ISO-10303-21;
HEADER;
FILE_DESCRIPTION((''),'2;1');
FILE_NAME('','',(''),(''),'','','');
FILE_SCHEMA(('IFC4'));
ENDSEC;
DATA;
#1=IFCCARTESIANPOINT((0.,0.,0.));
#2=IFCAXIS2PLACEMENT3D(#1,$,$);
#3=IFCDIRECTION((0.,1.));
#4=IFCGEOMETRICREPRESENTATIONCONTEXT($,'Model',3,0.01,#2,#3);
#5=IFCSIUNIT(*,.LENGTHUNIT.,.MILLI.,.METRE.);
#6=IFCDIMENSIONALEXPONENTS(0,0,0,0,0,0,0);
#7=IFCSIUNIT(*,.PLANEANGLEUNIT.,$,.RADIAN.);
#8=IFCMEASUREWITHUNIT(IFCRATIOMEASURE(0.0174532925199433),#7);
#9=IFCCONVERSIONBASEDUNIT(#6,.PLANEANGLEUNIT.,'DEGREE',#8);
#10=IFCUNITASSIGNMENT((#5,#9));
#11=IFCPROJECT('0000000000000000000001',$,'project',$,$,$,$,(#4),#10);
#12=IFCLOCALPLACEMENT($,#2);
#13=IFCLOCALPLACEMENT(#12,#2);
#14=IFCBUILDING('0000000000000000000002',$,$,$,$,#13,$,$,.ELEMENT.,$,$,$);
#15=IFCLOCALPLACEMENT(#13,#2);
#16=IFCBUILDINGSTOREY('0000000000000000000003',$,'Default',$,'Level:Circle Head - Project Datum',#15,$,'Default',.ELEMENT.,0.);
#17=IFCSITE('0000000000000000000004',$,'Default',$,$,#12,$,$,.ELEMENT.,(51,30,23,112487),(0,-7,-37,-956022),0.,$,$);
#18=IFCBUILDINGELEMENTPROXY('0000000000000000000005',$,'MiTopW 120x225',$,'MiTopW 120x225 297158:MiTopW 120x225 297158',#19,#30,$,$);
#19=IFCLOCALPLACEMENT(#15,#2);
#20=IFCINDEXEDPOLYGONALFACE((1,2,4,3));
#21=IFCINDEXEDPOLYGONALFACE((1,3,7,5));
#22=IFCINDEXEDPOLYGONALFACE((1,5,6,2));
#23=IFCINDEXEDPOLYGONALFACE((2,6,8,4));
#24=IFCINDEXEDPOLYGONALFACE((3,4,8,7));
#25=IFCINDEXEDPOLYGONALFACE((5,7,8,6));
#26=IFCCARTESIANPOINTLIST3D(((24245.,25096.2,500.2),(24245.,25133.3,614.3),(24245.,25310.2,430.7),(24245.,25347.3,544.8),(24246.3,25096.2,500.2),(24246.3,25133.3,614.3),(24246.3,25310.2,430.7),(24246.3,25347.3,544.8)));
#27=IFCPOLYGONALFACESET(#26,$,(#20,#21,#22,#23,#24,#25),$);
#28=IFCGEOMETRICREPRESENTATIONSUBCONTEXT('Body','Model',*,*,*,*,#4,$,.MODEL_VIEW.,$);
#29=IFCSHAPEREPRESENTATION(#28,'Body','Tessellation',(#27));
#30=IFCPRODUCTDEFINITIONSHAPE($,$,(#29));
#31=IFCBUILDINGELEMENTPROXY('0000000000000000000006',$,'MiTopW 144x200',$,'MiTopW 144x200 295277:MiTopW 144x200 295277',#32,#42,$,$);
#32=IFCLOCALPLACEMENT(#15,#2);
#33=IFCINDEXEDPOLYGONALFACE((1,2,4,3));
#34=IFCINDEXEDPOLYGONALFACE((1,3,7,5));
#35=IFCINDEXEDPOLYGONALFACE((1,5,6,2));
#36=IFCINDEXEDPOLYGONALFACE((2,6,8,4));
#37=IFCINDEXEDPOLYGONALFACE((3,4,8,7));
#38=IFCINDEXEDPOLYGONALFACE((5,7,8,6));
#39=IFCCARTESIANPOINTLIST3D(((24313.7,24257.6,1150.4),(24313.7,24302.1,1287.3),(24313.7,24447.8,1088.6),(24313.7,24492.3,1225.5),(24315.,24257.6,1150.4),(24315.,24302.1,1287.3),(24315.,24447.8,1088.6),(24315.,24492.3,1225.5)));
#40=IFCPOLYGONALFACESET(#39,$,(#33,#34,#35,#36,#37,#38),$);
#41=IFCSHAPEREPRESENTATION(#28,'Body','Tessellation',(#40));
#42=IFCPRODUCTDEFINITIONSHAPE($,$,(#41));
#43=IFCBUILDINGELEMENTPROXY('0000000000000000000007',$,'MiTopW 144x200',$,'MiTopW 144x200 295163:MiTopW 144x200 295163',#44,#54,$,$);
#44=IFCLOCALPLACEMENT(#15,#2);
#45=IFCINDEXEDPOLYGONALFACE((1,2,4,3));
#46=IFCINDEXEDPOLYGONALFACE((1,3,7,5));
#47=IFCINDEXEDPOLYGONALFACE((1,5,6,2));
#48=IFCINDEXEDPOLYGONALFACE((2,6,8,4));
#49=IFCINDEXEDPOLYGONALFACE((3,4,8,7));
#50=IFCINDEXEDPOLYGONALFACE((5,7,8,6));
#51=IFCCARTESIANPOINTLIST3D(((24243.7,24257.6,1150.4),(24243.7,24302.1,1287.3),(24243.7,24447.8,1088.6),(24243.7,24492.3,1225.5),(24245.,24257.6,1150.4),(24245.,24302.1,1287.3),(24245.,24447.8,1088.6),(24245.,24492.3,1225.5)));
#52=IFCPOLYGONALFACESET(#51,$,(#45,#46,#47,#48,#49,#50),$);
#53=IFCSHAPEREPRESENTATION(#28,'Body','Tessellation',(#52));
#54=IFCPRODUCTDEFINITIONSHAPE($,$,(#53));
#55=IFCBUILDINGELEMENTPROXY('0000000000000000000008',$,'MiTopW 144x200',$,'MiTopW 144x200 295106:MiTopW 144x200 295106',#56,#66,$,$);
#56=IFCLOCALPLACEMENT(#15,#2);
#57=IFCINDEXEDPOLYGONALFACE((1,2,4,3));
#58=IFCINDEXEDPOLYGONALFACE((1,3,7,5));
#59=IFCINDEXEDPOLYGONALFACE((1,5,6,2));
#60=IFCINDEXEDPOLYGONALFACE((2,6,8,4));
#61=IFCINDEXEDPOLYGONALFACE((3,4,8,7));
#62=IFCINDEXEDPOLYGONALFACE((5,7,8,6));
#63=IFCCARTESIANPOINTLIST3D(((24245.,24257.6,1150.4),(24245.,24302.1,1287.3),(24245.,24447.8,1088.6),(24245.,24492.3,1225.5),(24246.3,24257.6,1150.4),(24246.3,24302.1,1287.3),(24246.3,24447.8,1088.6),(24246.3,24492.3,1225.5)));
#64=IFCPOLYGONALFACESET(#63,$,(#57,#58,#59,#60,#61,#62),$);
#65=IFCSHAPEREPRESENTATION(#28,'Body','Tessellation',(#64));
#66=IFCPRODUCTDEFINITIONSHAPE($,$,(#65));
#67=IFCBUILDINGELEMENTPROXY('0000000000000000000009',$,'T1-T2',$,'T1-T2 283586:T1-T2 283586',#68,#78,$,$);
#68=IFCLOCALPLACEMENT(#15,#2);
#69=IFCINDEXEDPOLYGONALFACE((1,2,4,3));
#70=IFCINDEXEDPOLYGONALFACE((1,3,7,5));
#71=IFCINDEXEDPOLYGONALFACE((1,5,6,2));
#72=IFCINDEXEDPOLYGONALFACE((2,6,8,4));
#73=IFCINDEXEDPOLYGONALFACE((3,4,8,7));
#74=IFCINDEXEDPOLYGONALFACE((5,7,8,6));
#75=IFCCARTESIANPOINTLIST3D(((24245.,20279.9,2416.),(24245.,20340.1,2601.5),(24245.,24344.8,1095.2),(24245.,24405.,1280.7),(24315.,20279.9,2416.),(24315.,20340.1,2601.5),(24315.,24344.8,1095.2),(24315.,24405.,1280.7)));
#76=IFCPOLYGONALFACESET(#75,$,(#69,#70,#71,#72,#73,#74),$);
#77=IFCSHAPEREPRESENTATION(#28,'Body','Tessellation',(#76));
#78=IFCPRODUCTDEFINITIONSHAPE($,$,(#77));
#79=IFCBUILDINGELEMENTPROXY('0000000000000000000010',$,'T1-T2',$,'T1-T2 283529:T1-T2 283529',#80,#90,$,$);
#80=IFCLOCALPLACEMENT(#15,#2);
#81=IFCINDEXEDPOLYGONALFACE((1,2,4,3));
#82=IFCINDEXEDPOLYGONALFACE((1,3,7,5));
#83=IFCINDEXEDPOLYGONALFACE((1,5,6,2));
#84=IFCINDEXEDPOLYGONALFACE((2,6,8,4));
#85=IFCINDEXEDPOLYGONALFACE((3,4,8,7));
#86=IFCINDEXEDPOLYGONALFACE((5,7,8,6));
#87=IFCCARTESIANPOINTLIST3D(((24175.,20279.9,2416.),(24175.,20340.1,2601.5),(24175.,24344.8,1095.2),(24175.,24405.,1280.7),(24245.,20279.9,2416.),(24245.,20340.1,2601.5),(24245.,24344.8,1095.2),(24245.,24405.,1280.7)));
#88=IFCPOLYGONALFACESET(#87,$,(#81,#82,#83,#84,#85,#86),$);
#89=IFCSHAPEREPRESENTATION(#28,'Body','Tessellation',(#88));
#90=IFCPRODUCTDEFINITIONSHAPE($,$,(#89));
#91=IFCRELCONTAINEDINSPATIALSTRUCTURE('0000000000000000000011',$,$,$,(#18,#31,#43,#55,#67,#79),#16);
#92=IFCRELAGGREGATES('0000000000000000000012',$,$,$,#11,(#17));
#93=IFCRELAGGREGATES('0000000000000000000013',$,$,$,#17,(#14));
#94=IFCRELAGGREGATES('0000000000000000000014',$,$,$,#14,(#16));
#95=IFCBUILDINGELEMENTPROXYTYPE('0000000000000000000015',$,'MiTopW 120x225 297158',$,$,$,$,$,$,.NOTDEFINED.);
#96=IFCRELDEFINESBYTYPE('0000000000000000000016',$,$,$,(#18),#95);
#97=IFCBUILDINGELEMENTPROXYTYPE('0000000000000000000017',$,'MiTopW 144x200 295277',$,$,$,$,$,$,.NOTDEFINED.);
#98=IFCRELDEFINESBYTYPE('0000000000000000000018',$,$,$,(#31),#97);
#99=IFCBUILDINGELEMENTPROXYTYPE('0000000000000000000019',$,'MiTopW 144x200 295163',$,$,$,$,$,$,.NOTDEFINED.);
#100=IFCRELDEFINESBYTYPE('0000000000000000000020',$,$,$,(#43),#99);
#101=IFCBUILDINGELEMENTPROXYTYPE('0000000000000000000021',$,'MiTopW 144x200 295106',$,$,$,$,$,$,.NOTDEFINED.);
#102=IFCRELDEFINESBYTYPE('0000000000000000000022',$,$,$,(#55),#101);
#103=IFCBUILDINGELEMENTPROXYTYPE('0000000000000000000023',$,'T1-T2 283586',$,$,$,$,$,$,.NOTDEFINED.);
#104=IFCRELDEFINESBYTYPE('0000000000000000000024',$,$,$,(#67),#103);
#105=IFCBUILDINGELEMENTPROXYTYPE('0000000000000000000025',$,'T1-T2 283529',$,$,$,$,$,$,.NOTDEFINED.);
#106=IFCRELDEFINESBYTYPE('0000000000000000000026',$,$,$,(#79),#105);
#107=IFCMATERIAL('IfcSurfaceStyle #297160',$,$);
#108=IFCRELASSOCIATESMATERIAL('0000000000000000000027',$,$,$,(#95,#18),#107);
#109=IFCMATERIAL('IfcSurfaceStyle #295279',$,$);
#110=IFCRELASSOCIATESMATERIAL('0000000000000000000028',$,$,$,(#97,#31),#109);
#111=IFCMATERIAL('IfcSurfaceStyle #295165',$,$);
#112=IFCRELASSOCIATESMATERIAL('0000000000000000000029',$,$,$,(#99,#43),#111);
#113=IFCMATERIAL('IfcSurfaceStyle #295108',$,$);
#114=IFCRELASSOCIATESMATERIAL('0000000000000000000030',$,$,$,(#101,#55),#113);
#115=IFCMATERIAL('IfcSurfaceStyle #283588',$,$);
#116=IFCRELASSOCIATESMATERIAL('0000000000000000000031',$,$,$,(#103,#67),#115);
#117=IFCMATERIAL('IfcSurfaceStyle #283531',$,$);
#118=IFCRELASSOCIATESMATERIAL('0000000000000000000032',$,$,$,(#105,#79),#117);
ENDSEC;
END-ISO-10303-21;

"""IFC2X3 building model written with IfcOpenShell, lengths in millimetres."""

from ifc_helpers import new_model, entity, si_unit, converted_unit, direction, frame, origin, place, context, subcontext, project, spatial, polyline, outline, extrude, source, transform, mapped, material, type_object, type_shapes, element, save


model = new_model("IFC2X3")

# Units and contexts
model_context = context("Model", 3, precision=0.01, world=origin(), true_north=direction((0.0, 1.0)))
body_context = subcontext(model_context, "Body", "Model", "MODEL_VIEW")
ifc_project = project(units=[si_unit("LENGTHUNIT", "METRE", prefix="MILLI"), converted_unit("PLANEANGLEUNIT", "DEGREE", entity("IfcRatioMeasure", 0.0174532925199433), si_unit("PLANEANGLEUNIT", "RADIAN"), dimensions=[0, 0, 0, 0, 0, 0, 0])], contexts=[model_context])

# Site, building, storey
site_placement = place(None, origin())
site = spatial("IfcSite", under=ifc_project, at=site_placement, Name="Default", CompositionType="ELEMENT", RefLatitude=(51, 30, 23, 112487), RefLongitude=(0, -7, -37, -956022), RefElevation=0.0)
building_placement = place(site_placement, origin())
building = spatial("IfcBuilding", under=site, at=building_placement, CompositionType="ELEMENT")
storey_placement = place(building_placement, origin())
storey = spatial("IfcBuildingStorey", under=building, at=storey_placement, Name="Default", ObjectType="Level:Circle Head - Project Datum", LongName="Default", CompositionType="ELEMENT", Elevation=0.0)

# Building element proxies
ifc_material_1 = material(Name="IfcSurfaceStyle #297160")
building_element_proxy_type_1 = type_object("IfcBuildingElementProxyType", Name="MiTopW 120x225 297158", PredefinedType="NOTDEFINED", material=ifc_material_1)
shared_shape_1 = source(origin(), body_context, "Body", "SweptSolid", [
    extrude(outline(polyline([(-112.5, -60.0), (112.5, -60.0), (112.5, 60.0), (-112.5, 60.0), (-112.5, -60.0)])), frame((112.5, 60.0, 0.0), z_axis=(0.0, 0.0, 1.0), x_axis=(-1.0, 0.0, 0.0)), (0.0, 0.0, 1.0), 1.3),
])
type_shapes(building_element_proxy_type_1, [shared_shape_1])
proxy_1_placement = place(building_placement, frame((24246.3, 25310.2, 430.7), z_axis=(-1.0, 0.0, 0.0), x_axis=(0.0, -0.951057, 0.309017)))
element("IfcBuildingElementProxy", 1, at=proxy_1_placement, inside=storey, type_object=building_element_proxy_type_1, material=ifc_material_1, Name="MiTopW 120x225", ObjectType="MiTopW 120x225 297158:MiTopW 120x225 297158", context=body_context, shape_type="MappedRepresentation", body=[
    mapped(shared_shape_1, transform((0.0, 0.0, 0.0), scale=1.0)),
])
ifc_material_2 = material(Name="IfcSurfaceStyle #295279")
building_element_proxy_type_2 = type_object("IfcBuildingElementProxyType", Name="MiTopW 144x200 295277", PredefinedType="NOTDEFINED", material=ifc_material_2)
shared_shape_2 = source(origin(), body_context, "Body", "SweptSolid", [
    extrude(outline(polyline([(-100.0, -72.0), (100.0, -72.0), (100.0, 72.0), (-100.0, 72.0), (-100.0, -72.0)])), frame((100.0, 72.0, 0.0), z_axis=(0.0, 0.0, 1.0), x_axis=(-1.0, 0.0, 0.0)), (0.0, 0.0, 1.0), 1.3),
])
type_shapes(building_element_proxy_type_2, [shared_shape_2])
proxy_2_placement = place(building_placement, frame((24315.0, 24447.8, 1088.6), z_axis=(-1.0, 0.0, 0.0), x_axis=(0.0, -0.951057, 0.309017)))
element("IfcBuildingElementProxy", 2, at=proxy_2_placement, inside=storey, type_object=building_element_proxy_type_2, material=ifc_material_2, Name="MiTopW 144x200", ObjectType="MiTopW 144x200 295277:MiTopW 144x200 295277", context=body_context, shape_type="MappedRepresentation", body=[
    mapped(shared_shape_2, transform((0.0, 0.0, 0.0), scale=1.0)),
])
ifc_material_3 = material(Name="IfcSurfaceStyle #295165")
building_element_proxy_type_3 = type_object("IfcBuildingElementProxyType", Name="MiTopW 144x200 295163", PredefinedType="NOTDEFINED", material=ifc_material_3)
shared_shape_3 = source(origin(), body_context, "Body", "SweptSolid", [
    extrude(outline(polyline([(-100.0, -72.0), (100.0, -72.0), (100.0, 72.0), (-100.0, 72.0), (-100.0, -72.0)])), frame((100.0, 72.0, 0.0), z_axis=(0.0, 0.0, 1.0), x_axis=(-1.0, 0.0, 0.0)), (0.0, 0.0, 1.0), 1.3),
])
type_shapes(building_element_proxy_type_3, [shared_shape_3])
proxy_3_placement = place(building_placement, frame((24245.0, 24447.8, 1088.6), z_axis=(-1.0, 0.0, 0.0), x_axis=(0.0, -0.951057, 0.309017)))
element("IfcBuildingElementProxy", 3, at=proxy_3_placement, inside=storey, type_object=building_element_proxy_type_3, material=ifc_material_3, Name="MiTopW 144x200", ObjectType="MiTopW 144x200 295163:MiTopW 144x200 295163", context=body_context, shape_type="MappedRepresentation", body=[
    mapped(shared_shape_3, transform((0.0, 0.0, 0.0), scale=1.0)),
])
ifc_material_4 = material(Name="IfcSurfaceStyle #295108")
building_element_proxy_type_4 = type_object("IfcBuildingElementProxyType", Name="MiTopW 144x200 295106", PredefinedType="NOTDEFINED", material=ifc_material_4)
shared_shape_4 = source(origin(), body_context, "Body", "SweptSolid", [
    extrude(outline(polyline([(-100.0, -72.0), (100.0, -72.0), (100.0, 72.0), (-100.0, 72.0), (-100.0, -72.0)])), frame((100.0, 72.0, 0.0), z_axis=(0.0, 0.0, 1.0), x_axis=(-1.0, 0.0, 0.0)), (0.0, 0.0, 1.0), 1.3),
])
type_shapes(building_element_proxy_type_4, [shared_shape_4])
proxy_4_placement = place(building_placement, frame((24246.3, 24447.8, 1088.6), z_axis=(-1.0, 0.0, 0.0), x_axis=(0.0, -0.951057, 0.309017)))
element("IfcBuildingElementProxy", 4, at=proxy_4_placement, inside=storey, type_object=building_element_proxy_type_4, material=ifc_material_4, Name="MiTopW 144x200", ObjectType="MiTopW 144x200 295106:MiTopW 144x200 295106", context=body_context, shape_type="MappedRepresentation", body=[
    mapped(shared_shape_4, transform((0.0, 0.0, 0.0), scale=1.0)),
])
ifc_material_5 = material(Name="IfcSurfaceStyle #283588")
building_element_proxy_type_5 = type_object("IfcBuildingElementProxyType", Name="T1-T2 283586", PredefinedType="NOTDEFINED", material=ifc_material_5)
shared_shape_5 = source(origin(), body_context, "Body", "SweptSolid", [
    extrude(outline(polyline([(-2137.0, -97.5), (2137.0, -97.5), (2137.0, 97.5), (-2137.0, 97.5), (-2137.0, -97.5)])), frame((2137.0, 97.5, 0.0), z_axis=(0.0, 0.0, 1.0), x_axis=(-1.0, 0.0, 0.0)), (0.0, 0.0, 1.0), 70.0),
])
type_shapes(building_element_proxy_type_5, [shared_shape_5])
proxy_5_placement = place(building_placement, frame((24315.0, 24344.8, 1095.2), z_axis=(-1.0, 0.0, 0.0), x_axis=(0.0, -0.951057, 0.309017)))
element("IfcBuildingElementProxy", 5, at=proxy_5_placement, inside=storey, type_object=building_element_proxy_type_5, material=ifc_material_5, Name="T1-T2", ObjectType="T1-T2 283586:T1-T2 283586", context=body_context, shape_type="MappedRepresentation", body=[
    mapped(shared_shape_5, transform((0.0, 0.0, 0.0), scale=1.0)),
])
ifc_material_6 = material(Name="IfcSurfaceStyle #283531")
building_element_proxy_type_6 = type_object("IfcBuildingElementProxyType", Name="T1-T2 283529", PredefinedType="NOTDEFINED", material=ifc_material_6)
shared_shape_6 = source(origin(), body_context, "Body", "SweptSolid", [
    extrude(outline(polyline([(-2137.0, -97.5), (2137.0, -97.5), (2137.0, 97.5), (-2137.0, 97.5), (-2137.0, -97.5)])), frame((2137.0, 97.5, 0.0), z_axis=(0.0, 0.0, 1.0), x_axis=(-1.0, 0.0, 0.0)), (0.0, 0.0, 1.0), 70.0),
])
type_shapes(building_element_proxy_type_6, [shared_shape_6])
proxy_6_placement = place(building_placement, frame((24245.0, 24344.8, 1095.2), z_axis=(-1.0, 0.0, 0.0), x_axis=(0.0, -0.951057, 0.309017)))
element("IfcBuildingElementProxy", 6, at=proxy_6_placement, inside=storey, type_object=building_element_proxy_type_6, material=ifc_material_6, Name="T1-T2", ObjectType="T1-T2 283529:T1-T2 283529", context=body_context, shape_type="MappedRepresentation", body=[
    mapped(shared_shape_6, transform((0.0, 0.0, 0.0), scale=1.0)),
])

save(model, "model.ifc")
